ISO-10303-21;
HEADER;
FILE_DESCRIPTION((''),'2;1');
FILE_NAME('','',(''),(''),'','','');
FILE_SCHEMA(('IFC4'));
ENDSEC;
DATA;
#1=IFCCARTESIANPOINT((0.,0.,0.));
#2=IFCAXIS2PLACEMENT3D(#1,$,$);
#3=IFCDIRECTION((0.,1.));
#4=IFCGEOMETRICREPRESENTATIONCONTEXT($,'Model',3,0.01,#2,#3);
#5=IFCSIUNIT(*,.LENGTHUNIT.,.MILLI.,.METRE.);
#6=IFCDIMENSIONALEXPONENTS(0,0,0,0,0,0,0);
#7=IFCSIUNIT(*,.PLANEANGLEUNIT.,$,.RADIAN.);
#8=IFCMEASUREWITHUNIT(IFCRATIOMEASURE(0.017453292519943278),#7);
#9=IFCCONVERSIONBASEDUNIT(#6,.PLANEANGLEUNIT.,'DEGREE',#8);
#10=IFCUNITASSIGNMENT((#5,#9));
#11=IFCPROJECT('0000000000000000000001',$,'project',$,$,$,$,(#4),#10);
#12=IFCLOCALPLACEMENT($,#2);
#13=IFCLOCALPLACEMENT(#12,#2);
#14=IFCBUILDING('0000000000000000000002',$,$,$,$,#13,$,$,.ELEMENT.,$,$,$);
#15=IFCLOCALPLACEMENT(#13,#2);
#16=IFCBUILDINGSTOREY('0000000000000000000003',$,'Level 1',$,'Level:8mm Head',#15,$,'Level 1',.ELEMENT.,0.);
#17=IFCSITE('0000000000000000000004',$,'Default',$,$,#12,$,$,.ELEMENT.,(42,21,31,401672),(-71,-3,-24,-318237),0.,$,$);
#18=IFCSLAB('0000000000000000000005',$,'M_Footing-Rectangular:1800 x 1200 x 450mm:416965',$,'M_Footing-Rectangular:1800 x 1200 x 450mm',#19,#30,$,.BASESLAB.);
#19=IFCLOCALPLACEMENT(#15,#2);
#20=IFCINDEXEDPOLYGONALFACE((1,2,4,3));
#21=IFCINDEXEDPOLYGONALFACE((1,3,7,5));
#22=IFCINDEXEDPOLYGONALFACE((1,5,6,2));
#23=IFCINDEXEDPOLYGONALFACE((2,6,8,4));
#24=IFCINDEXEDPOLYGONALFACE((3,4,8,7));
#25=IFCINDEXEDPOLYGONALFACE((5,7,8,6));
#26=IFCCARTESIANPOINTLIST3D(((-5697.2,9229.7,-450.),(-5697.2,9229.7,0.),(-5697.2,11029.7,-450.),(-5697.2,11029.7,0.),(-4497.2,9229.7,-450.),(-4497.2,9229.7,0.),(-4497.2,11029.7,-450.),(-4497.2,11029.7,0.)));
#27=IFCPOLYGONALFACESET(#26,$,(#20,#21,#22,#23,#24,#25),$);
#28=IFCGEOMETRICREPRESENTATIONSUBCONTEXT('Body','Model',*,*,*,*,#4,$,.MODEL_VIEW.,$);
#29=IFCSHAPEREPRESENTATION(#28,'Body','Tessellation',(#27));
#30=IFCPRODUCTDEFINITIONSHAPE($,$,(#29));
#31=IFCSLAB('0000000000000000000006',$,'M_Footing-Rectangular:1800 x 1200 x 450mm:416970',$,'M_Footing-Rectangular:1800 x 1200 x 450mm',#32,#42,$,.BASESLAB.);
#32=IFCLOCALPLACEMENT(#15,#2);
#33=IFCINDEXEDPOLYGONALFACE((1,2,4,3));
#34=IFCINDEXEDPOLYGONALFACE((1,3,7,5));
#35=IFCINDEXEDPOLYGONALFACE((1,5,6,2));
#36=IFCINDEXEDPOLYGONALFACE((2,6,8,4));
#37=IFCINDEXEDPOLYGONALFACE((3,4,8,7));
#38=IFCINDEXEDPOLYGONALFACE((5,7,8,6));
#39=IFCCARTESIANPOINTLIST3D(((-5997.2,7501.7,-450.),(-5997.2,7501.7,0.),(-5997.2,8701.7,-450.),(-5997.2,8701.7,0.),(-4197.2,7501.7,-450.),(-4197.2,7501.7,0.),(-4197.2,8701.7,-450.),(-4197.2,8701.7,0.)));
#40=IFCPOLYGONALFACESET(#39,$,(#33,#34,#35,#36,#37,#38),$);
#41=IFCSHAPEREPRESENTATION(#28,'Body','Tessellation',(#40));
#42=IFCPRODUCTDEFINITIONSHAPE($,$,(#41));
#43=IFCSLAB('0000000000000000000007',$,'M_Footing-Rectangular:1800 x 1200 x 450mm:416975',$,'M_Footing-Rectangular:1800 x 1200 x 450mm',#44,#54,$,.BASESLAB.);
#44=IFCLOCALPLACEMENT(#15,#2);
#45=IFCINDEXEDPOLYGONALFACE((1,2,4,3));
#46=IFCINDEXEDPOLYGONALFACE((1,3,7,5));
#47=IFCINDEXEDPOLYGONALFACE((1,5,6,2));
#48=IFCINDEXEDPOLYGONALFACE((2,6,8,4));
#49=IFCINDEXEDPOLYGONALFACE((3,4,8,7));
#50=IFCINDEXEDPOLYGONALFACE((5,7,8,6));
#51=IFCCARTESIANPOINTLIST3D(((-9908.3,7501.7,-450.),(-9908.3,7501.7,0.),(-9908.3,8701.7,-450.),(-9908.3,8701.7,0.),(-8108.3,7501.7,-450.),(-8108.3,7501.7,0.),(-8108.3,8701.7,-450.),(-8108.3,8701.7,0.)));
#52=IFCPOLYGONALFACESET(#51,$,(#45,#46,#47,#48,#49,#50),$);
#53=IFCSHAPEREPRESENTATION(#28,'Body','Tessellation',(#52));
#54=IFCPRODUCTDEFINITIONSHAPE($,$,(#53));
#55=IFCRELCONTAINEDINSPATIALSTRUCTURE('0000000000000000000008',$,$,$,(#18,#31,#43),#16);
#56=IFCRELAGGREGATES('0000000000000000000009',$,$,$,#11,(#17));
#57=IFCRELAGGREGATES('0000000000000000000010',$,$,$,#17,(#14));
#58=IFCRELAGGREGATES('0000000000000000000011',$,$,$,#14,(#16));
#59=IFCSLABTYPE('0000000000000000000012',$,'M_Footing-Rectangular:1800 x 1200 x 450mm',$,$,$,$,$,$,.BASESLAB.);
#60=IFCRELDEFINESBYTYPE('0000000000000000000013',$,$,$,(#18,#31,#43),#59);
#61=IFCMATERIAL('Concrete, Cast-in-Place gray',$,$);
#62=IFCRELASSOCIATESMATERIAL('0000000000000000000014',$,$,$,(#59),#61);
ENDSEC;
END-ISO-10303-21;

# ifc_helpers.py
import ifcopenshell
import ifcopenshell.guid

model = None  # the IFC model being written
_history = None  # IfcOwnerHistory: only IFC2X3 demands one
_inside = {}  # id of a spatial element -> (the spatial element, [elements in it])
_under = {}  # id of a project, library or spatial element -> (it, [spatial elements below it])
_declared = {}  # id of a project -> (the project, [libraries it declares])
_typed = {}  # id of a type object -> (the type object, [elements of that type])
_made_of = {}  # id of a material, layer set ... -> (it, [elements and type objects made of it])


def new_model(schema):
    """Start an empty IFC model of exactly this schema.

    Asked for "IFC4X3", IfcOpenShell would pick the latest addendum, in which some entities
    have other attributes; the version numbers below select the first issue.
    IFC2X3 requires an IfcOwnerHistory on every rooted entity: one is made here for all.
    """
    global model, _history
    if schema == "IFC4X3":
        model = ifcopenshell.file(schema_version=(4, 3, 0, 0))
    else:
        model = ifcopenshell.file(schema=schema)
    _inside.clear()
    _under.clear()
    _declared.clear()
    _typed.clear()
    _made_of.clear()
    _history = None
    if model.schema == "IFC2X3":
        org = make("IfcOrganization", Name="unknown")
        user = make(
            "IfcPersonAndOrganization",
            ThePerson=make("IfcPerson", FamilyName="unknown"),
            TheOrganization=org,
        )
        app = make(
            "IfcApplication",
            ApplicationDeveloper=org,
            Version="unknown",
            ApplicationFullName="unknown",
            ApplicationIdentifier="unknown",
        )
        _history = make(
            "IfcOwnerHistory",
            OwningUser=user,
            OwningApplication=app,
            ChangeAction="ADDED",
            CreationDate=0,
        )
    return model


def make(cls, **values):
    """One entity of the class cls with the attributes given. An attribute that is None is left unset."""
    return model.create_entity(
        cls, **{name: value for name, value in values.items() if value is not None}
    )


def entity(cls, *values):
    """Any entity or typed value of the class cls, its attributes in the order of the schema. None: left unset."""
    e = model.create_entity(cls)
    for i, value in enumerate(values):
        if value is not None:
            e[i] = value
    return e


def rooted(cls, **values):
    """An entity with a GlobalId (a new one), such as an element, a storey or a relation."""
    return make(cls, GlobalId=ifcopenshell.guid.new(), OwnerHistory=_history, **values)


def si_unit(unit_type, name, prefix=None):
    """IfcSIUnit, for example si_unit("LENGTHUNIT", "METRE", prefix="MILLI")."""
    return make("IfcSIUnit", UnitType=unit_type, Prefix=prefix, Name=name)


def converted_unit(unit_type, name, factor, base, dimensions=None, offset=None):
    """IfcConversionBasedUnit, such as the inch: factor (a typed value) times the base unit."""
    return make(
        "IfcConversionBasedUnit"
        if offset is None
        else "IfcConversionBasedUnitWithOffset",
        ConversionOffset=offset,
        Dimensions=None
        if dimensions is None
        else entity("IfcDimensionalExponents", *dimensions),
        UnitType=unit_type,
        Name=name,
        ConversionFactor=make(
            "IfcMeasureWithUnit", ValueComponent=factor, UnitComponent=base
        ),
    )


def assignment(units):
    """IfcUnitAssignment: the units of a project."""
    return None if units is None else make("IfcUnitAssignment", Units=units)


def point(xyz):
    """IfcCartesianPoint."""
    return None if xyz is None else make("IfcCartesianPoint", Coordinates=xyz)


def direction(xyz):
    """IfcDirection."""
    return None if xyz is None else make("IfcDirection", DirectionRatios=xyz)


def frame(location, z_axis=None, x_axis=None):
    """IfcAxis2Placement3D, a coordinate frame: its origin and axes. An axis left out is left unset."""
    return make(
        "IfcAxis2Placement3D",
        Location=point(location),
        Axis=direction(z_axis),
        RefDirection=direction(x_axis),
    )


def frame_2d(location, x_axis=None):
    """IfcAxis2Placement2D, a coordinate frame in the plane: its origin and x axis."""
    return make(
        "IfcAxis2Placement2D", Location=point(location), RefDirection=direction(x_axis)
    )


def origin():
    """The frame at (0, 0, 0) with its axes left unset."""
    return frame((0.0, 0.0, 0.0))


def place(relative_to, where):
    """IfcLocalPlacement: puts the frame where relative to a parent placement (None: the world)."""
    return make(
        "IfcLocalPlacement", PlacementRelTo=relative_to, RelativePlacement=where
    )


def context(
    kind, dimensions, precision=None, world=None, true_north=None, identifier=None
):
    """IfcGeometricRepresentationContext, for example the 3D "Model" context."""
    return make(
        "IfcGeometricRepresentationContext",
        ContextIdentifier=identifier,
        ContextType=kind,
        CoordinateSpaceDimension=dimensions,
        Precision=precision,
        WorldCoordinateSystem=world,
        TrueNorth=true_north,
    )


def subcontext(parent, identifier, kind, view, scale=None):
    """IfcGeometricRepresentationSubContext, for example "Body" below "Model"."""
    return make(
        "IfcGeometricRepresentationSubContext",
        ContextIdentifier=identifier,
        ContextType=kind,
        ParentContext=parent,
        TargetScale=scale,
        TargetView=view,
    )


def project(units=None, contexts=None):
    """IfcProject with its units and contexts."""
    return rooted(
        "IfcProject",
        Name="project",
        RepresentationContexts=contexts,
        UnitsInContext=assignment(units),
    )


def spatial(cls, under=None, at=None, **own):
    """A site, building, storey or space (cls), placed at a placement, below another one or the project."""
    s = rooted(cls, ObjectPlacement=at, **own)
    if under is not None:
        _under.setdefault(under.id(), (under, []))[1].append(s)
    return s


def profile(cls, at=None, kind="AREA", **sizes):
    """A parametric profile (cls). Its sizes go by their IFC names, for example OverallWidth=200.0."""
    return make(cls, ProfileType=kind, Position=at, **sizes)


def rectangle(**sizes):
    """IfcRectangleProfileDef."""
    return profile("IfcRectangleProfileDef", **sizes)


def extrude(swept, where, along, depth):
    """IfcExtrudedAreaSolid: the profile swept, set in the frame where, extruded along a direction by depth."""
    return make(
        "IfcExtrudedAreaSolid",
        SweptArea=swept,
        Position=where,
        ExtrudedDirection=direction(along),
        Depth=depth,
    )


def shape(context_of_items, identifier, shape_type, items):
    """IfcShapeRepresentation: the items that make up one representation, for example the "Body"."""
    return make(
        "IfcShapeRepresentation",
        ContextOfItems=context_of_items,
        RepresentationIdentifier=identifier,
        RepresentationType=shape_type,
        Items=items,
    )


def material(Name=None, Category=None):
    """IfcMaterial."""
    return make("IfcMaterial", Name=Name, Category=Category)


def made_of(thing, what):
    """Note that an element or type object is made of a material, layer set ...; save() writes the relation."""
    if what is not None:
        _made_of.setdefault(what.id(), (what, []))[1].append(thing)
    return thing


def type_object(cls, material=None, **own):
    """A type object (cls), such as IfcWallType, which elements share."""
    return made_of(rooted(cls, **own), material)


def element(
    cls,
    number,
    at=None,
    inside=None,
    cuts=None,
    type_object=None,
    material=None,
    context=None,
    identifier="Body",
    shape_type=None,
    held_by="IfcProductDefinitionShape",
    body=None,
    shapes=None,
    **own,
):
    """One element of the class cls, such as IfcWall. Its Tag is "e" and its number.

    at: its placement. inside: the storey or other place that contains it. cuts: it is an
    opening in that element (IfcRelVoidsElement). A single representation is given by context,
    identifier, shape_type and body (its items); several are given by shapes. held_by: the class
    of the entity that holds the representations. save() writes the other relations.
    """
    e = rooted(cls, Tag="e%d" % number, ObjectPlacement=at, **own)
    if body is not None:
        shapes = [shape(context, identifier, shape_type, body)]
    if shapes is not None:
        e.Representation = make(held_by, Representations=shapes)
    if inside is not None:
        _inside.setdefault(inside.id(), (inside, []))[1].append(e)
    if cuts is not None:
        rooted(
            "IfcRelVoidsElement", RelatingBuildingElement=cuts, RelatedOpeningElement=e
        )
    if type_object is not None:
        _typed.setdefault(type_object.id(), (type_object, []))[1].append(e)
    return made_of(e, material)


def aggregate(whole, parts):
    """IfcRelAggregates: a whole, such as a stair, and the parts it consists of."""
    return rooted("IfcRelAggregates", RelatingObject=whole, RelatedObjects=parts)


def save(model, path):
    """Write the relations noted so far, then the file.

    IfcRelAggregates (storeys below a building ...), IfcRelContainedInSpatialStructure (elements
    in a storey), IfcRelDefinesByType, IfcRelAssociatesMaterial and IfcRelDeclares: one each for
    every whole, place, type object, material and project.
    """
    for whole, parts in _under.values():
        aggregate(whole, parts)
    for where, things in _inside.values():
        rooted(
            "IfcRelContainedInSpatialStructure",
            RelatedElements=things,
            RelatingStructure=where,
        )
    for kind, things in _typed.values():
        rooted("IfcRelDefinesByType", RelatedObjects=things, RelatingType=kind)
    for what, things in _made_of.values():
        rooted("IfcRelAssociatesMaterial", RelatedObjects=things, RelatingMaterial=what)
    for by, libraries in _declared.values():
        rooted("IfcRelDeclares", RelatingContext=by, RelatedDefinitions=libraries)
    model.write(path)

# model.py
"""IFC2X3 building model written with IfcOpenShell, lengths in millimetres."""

from ifc_helpers import new_model, entity, si_unit, converted_unit, direction, frame, frame_2d, origin, place, context, subcontext, project, spatial, rectangle, extrude, material, type_object, element, save


model = new_model("IFC2X3")

# Units and contexts
model_context = context("Model", 3, precision=0.01, world=origin(), true_north=direction((0.0, 1.0)))
body_context = subcontext(model_context, "Body", "Model", "MODEL_VIEW")
ifc_project = project(units=[si_unit("LENGTHUNIT", "METRE", prefix="MILLI"), converted_unit("PLANEANGLEUNIT", "DEGREE", entity("IfcRatioMeasure", 0.017453292519943278), si_unit("PLANEANGLEUNIT", "RADIAN"), dimensions=[0, 0, 0, 0, 0, 0, 0])], contexts=[model_context])

# Site, building, storey
site_placement = place(None, origin())
site = spatial("IfcSite", under=ifc_project, at=site_placement, Name="Default", CompositionType="ELEMENT", RefLatitude=(42, 21, 31, 401672), RefLongitude=(-71, -3, -24, -318237), RefElevation=0.0)
building_placement = place(site_placement, origin())
building = spatial("IfcBuilding", under=site, at=building_placement, CompositionType="ELEMENT")
storey_placement = place(building_placement, origin())
storey = spatial("IfcBuildingStorey", under=building, at=storey_placement, Name="Level 1", ObjectType="Level:8mm Head", LongName="Level 1", CompositionType="ELEMENT", Elevation=0.0)

# Slabs
ifc_material_1 = material(Name="Concrete, Cast-in-Place gray")
slab_type = type_object("IfcSlabType", Name="M_Footing-Rectangular:1800 x 1200 x 450mm", PredefinedType="BASESLAB", material=ifc_material_1)
slab_1_placement = place(storey_placement, origin())
element("IfcSlab", 1, at=slab_1_placement, inside=storey, type_object=slab_type, Name="M_Footing-Rectangular:1800 x 1200 x 450mm:416965", ObjectType="M_Footing-Rectangular:1800 x 1200 x 450mm", PredefinedType="BASESLAB", context=body_context, shape_type="SweptSolid", body=[
    extrude(rectangle(XDim=1200.0, YDim=1800.0, at=frame_2d((0.0, 0.0), x_axis=(1.0, 0.0))), frame((-5097.2, 10129.7, -450.0), z_axis=(0.0, 0.0, 1.0), x_axis=(-1.0, 0.0, 0.0)), (0.0, 0.0, 1.0), 450.0),
])
slab_2_placement = place(storey_placement, origin())
element("IfcSlab", 2, at=slab_2_placement, inside=storey, type_object=slab_type, Name="M_Footing-Rectangular:1800 x 1200 x 450mm:416970", ObjectType="M_Footing-Rectangular:1800 x 1200 x 450mm", PredefinedType="BASESLAB", context=body_context, shape_type="SweptSolid", body=[
    extrude(rectangle(XDim=1200.0, YDim=1800.0, at=frame_2d((0.0, 0.0), x_axis=(1.0, 0.0))), frame((-5097.2, 8101.7, -450.0), z_axis=(0.0, 0.0, 1.0), x_axis=(0.0, -1.0, 0.0)), (0.0, 0.0, 1.0), 450.0),
])
slab_3_placement = place(storey_placement, origin())
element("IfcSlab", 3, at=slab_3_placement, inside=storey, type_object=slab_type, Name="M_Footing-Rectangular:1800 x 1200 x 450mm:416975", ObjectType="M_Footing-Rectangular:1800 x 1200 x 450mm", PredefinedType="BASESLAB", context=body_context, shape_type="SweptSolid", body=[
    extrude(rectangle(XDim=1200.0, YDim=1800.0, at=frame_2d((0.0, 0.0), x_axis=(1.0, 0.0))), frame((-9008.3, 8101.7, -450.0), z_axis=(0.0, 0.0, 1.0), x_axis=(0.0, -1.0, 0.0)), (0.0, 0.0, 1.0), 450.0),
])

save(model, "model.ifc")
